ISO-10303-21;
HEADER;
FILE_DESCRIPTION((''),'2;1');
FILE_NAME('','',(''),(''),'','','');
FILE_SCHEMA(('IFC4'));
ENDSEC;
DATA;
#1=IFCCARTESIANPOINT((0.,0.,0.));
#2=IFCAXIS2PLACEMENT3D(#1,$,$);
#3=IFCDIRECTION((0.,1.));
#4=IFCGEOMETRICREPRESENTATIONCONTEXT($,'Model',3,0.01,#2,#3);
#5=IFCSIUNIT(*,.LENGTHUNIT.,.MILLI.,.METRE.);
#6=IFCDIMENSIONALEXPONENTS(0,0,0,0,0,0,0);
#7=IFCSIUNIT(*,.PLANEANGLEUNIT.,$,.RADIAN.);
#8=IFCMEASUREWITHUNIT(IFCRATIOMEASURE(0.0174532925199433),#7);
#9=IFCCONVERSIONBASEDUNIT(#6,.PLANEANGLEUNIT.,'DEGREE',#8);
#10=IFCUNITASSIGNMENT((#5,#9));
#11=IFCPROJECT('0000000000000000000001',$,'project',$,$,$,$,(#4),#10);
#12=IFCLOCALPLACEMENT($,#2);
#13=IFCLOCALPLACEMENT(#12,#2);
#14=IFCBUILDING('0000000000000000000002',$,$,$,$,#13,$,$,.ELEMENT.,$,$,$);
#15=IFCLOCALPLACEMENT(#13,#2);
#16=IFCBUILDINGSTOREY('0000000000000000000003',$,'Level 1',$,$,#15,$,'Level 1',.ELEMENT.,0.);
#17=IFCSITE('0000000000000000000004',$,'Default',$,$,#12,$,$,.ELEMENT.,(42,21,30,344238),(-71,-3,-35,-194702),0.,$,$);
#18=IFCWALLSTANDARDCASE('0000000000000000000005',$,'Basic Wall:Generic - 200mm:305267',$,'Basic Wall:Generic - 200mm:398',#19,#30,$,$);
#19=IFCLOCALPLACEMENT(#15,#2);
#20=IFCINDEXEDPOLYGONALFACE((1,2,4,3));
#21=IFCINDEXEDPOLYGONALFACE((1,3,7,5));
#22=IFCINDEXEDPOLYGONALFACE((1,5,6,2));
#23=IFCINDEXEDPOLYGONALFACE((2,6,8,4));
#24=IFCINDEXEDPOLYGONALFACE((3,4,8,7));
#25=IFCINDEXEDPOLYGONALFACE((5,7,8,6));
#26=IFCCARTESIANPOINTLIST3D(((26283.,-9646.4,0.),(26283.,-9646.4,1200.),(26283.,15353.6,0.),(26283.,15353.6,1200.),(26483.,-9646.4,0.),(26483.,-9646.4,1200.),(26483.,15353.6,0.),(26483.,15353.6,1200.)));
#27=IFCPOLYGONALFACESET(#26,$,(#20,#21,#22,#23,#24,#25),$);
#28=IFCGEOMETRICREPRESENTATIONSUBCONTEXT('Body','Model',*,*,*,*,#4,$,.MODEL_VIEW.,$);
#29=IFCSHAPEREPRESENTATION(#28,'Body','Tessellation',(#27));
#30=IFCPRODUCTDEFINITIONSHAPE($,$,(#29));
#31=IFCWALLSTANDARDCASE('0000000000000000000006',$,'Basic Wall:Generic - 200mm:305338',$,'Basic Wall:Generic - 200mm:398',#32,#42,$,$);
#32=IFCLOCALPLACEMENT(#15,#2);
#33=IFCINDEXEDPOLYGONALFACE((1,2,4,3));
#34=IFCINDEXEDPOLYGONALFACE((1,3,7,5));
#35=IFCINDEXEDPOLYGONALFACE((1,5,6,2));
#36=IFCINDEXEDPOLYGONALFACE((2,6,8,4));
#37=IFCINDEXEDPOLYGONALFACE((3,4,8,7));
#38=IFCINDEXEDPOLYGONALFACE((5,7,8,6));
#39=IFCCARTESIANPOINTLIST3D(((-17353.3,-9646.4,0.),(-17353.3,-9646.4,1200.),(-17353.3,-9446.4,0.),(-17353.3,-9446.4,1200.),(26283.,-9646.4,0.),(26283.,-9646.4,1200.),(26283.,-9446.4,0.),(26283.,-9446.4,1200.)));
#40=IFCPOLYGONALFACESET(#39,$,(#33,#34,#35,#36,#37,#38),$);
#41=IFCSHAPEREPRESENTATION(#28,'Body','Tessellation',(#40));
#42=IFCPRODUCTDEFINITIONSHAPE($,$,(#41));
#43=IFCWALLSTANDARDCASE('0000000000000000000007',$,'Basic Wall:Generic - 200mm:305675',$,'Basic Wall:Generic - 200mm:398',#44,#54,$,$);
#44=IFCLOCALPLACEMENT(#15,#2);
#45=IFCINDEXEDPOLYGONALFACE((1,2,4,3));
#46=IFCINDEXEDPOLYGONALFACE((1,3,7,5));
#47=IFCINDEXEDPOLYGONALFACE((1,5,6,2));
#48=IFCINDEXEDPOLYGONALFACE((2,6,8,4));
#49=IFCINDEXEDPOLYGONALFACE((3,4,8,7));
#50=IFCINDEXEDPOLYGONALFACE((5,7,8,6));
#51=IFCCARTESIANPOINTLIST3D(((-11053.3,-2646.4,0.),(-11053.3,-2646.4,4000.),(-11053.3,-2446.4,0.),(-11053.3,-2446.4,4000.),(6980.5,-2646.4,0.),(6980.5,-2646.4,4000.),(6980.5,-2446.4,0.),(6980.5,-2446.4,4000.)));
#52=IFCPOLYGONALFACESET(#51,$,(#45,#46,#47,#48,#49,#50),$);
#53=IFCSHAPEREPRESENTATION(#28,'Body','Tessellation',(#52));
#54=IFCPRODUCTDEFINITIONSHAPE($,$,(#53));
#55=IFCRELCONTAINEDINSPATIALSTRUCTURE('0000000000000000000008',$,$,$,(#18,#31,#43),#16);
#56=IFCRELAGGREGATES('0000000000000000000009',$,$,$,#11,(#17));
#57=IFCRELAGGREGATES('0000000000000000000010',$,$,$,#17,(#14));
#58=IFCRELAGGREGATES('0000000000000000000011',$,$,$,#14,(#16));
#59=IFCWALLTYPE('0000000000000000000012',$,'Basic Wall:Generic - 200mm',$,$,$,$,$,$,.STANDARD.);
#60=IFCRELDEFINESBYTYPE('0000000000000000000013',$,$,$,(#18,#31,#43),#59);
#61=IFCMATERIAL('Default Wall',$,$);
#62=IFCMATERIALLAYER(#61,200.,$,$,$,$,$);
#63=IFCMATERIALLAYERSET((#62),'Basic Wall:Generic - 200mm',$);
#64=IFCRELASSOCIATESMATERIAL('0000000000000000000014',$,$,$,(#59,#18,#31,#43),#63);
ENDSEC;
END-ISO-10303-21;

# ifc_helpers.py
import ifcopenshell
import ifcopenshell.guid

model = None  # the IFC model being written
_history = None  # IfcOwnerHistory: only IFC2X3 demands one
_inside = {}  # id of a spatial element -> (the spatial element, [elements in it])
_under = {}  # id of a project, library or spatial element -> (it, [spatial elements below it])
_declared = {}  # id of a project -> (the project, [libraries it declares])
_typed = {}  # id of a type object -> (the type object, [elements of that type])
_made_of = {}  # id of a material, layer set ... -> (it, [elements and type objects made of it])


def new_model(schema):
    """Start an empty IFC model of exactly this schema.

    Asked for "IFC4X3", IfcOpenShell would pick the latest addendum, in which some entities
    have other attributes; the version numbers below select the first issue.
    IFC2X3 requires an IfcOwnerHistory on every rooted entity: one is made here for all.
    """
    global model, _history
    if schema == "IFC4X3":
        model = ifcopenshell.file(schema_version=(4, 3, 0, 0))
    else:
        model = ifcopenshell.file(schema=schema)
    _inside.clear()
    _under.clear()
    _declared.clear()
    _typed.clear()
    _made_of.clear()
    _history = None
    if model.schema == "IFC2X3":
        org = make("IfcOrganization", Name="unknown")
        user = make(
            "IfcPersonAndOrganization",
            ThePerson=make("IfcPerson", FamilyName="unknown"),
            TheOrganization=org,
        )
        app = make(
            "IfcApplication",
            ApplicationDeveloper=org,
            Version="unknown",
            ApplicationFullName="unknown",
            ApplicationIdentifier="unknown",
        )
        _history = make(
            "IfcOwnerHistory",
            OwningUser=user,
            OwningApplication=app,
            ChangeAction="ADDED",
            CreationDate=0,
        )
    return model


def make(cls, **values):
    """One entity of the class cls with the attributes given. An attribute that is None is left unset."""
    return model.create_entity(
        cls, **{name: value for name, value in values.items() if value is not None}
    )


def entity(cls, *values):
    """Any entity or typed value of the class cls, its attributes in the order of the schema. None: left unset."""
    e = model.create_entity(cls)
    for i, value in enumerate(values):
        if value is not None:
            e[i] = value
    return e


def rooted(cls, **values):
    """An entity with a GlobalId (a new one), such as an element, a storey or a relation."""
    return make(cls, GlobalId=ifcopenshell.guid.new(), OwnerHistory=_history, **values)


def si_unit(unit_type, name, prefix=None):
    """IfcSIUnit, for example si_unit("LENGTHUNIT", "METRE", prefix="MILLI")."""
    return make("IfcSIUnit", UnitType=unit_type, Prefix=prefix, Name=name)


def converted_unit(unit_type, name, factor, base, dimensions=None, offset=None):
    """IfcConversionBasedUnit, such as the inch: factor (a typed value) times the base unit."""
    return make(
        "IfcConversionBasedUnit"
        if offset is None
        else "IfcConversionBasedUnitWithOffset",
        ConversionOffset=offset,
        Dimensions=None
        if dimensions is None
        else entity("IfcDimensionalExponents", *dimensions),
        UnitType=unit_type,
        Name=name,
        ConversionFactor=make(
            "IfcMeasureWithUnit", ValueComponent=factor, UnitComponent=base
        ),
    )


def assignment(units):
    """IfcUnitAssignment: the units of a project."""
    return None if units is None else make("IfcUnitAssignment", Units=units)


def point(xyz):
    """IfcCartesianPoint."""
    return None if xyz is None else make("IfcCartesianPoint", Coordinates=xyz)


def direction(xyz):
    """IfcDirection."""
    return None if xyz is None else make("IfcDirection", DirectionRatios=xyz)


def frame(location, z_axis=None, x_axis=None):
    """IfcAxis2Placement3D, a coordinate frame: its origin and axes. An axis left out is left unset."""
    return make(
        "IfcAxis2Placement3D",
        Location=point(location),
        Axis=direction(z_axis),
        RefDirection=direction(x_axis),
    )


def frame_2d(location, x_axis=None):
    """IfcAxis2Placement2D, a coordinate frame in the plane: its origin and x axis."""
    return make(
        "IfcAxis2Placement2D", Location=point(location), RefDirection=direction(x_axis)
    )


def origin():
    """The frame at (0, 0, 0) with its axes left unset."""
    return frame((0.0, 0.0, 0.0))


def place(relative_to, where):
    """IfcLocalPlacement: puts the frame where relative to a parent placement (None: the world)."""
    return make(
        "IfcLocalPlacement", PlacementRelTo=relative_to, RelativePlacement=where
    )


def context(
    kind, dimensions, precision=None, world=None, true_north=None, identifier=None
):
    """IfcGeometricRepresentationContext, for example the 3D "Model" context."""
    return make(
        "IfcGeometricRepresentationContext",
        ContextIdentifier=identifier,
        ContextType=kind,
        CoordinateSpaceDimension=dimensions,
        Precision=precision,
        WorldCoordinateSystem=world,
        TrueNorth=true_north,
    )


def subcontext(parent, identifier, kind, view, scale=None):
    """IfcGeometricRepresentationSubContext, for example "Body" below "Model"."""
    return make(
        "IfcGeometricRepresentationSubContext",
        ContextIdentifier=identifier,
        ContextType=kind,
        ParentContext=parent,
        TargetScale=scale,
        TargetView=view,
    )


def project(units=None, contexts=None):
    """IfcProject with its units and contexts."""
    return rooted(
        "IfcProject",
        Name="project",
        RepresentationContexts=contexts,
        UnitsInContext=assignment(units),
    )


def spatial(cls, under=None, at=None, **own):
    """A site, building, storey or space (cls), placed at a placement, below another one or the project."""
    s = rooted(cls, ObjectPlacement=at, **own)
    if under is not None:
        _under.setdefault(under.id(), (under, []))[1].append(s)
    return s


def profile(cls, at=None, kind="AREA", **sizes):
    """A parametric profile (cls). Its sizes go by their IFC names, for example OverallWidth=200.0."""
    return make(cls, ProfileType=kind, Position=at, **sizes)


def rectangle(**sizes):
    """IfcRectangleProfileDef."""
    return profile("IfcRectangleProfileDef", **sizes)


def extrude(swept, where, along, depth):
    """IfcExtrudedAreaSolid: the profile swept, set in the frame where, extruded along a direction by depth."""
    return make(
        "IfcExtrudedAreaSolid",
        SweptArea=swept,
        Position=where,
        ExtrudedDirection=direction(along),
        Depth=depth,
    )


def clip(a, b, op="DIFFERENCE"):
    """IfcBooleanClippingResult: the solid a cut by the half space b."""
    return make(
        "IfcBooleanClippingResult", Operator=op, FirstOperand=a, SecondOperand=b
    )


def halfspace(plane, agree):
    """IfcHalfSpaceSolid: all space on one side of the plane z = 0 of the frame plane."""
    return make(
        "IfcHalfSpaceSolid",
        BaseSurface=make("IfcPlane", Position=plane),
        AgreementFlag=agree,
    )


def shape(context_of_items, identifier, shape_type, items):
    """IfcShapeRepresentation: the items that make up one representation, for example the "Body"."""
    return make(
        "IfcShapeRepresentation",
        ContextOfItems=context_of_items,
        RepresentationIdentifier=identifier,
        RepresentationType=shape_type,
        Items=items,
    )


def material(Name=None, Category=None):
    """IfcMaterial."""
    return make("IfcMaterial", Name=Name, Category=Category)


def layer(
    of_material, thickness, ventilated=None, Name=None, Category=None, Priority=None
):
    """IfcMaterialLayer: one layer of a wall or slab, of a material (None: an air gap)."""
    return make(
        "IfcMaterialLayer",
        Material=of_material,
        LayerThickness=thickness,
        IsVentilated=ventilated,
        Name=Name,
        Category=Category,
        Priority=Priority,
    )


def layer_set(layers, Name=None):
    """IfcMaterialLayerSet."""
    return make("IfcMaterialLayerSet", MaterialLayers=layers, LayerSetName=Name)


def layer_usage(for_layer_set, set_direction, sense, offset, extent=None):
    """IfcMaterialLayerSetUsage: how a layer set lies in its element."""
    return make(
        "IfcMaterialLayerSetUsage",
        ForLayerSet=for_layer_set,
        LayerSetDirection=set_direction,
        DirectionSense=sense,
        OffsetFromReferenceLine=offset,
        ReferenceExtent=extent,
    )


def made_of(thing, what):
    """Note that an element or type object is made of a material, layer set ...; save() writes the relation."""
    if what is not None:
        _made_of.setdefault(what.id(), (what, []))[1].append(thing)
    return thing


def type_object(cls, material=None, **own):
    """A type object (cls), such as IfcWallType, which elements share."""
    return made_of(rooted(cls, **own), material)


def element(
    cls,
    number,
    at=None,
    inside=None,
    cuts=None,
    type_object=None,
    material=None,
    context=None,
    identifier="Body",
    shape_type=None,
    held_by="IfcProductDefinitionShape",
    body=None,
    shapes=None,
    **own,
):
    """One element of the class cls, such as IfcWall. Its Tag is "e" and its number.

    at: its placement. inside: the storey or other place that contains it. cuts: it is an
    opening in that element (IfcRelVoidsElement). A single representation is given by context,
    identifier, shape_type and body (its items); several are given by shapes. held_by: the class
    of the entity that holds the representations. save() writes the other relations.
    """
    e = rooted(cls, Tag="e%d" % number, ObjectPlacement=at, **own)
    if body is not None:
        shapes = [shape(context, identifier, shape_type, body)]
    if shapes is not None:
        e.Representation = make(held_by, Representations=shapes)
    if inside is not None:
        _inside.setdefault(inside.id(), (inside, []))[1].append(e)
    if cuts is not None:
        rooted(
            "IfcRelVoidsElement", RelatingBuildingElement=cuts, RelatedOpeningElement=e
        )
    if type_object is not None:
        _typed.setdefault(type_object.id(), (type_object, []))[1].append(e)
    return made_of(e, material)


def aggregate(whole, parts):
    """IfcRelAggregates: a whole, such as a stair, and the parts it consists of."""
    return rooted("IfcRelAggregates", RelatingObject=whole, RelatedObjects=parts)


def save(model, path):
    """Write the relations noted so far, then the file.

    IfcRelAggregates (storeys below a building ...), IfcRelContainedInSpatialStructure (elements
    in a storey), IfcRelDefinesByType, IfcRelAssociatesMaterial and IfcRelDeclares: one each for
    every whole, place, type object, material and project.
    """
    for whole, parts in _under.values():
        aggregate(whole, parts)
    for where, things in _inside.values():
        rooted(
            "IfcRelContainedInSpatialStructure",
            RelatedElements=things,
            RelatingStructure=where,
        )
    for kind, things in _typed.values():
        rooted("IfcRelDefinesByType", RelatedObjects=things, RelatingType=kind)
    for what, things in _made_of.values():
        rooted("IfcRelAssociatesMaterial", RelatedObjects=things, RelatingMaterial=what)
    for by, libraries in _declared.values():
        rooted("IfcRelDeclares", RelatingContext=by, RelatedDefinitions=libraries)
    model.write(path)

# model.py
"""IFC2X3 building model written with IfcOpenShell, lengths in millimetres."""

from ifc_helpers import new_model, entity, si_unit, converted_unit, direction, frame, frame_2d, origin, place, context, subcontext, project, spatial, rectangle, extrude, clip, halfspace, material, layer, layer_set, layer_usage, type_object, element, save


model = new_model("IFC2X3")

# Units and contexts
model_context = context("Model", 3, precision=0.01, world=origin(), true_north=direction((0.0, 1.0)))
body_context = subcontext(model_context, "Body", "Model", "MODEL_VIEW")
ifc_project = project(units=[si_unit("LENGTHUNIT", "METRE", prefix="MILLI"), converted_unit("PLANEANGLEUNIT", "DEGREE", entity("IfcRatioMeasure", 0.0174532925199433), si_unit("PLANEANGLEUNIT", "RADIAN"), dimensions=[0, 0, 0, 0, 0, 0, 0])], contexts=[model_context])

# Site, building, storey
site_placement = place(None, origin())
site = spatial("IfcSite", under=ifc_project, at=site_placement, Name="Default", CompositionType="ELEMENT", RefLatitude=(42, 21, 30, 344238), RefLongitude=(-71, -3, -35, -194702), RefElevation=0.0)
building_placement = place(site_placement, origin())
building = spatial("IfcBuilding", under=site, at=building_placement, CompositionType="ELEMENT")
storey_placement = place(building_placement, origin())
storey = spatial("IfcBuildingStorey", under=building, at=storey_placement, Name="Level 1", LongName="Level 1", CompositionType="ELEMENT", Elevation=0.0)

# Walls
ifc_material_1 = material(Name="Default Wall")
ifc_layer = layer(ifc_material_1, 200.0)
ifc_layer_set = layer_set([ifc_layer], Name="Basic Wall:Generic - 200mm")
ifc_layer_usage_1 = layer_usage(ifc_layer_set, "AXIS2", "NEGATIVE", 100.0)
wall_type = type_object("IfcWallType", Name="Basic Wall:Generic - 200mm", PredefinedType="STANDARD", material=ifc_layer_set)
wall_1_placement = place(storey_placement, frame((26383.0, 15353.6, 0.0), z_axis=(0.0, 0.0, 1.0), x_axis=(0.0, -1.0, 0.0)))
element("IfcWallStandardCase", 1, at=wall_1_placement, inside=storey, type_object=wall_type, material=ifc_layer_usage_1, Name="Basic Wall:Generic - 200mm:305267", ObjectType="Basic Wall:Generic - 200mm:398", context=body_context, shape_type="SweptSolid", body=[
    extrude(rectangle(XDim=25000.0, YDim=200.0, at=frame_2d((12500.0, 0.0), x_axis=(-1.0, 0.0))), origin(), (0.0, 0.0, 1.0), 1200.0),
])
ifc_layer_usage_2 = layer_usage(ifc_layer_set, "AXIS2", "NEGATIVE", 100.0)
wall_2_placement = place(storey_placement, frame((26283.0, -9546.4, 0.0), z_axis=(0.0, 0.0, 1.0), x_axis=(-1.0, 0.0, 0.0)))
element("IfcWallStandardCase", 2, at=wall_2_placement, inside=storey, type_object=wall_type, material=ifc_layer_usage_2, Name="Basic Wall:Generic - 200mm:305338", ObjectType="Basic Wall:Generic - 200mm:398", context=body_context, shape_type="SweptSolid", body=[
    extrude(rectangle(XDim=43636.3, YDim=200.0, at=frame_2d((21818.1, 0.0), x_axis=(-1.0, 0.0))), origin(), (0.0, 0.0, 1.0), 1200.0),
])
ifc_layer_usage_3 = layer_usage(ifc_layer_set, "AXIS2", "NEGATIVE", 100.0)
wall_3_placement = place(storey_placement, frame((6980.5, -2546.4, 0.0), z_axis=(0.0, 0.0, 1.0), x_axis=(-1.0, 0.0, 0.0)))
element("IfcWallStandardCase", 3, at=wall_3_placement, inside=storey, type_object=wall_type, material=ifc_layer_usage_3, Name="Basic Wall:Generic - 200mm:305675", ObjectType="Basic Wall:Generic - 200mm:398", context=body_context, shape_type="Clipping", body=[
    clip(extrude(rectangle(XDim=18033.8, YDim=200.0, at=frame_2d((9016.9, 0.0), x_axis=(-1.0, 0.0))), origin(), (0.0, 0.0, 1.0), 4000.0), halfspace(origin(), True)),
])

save(model, "model.ifc")
